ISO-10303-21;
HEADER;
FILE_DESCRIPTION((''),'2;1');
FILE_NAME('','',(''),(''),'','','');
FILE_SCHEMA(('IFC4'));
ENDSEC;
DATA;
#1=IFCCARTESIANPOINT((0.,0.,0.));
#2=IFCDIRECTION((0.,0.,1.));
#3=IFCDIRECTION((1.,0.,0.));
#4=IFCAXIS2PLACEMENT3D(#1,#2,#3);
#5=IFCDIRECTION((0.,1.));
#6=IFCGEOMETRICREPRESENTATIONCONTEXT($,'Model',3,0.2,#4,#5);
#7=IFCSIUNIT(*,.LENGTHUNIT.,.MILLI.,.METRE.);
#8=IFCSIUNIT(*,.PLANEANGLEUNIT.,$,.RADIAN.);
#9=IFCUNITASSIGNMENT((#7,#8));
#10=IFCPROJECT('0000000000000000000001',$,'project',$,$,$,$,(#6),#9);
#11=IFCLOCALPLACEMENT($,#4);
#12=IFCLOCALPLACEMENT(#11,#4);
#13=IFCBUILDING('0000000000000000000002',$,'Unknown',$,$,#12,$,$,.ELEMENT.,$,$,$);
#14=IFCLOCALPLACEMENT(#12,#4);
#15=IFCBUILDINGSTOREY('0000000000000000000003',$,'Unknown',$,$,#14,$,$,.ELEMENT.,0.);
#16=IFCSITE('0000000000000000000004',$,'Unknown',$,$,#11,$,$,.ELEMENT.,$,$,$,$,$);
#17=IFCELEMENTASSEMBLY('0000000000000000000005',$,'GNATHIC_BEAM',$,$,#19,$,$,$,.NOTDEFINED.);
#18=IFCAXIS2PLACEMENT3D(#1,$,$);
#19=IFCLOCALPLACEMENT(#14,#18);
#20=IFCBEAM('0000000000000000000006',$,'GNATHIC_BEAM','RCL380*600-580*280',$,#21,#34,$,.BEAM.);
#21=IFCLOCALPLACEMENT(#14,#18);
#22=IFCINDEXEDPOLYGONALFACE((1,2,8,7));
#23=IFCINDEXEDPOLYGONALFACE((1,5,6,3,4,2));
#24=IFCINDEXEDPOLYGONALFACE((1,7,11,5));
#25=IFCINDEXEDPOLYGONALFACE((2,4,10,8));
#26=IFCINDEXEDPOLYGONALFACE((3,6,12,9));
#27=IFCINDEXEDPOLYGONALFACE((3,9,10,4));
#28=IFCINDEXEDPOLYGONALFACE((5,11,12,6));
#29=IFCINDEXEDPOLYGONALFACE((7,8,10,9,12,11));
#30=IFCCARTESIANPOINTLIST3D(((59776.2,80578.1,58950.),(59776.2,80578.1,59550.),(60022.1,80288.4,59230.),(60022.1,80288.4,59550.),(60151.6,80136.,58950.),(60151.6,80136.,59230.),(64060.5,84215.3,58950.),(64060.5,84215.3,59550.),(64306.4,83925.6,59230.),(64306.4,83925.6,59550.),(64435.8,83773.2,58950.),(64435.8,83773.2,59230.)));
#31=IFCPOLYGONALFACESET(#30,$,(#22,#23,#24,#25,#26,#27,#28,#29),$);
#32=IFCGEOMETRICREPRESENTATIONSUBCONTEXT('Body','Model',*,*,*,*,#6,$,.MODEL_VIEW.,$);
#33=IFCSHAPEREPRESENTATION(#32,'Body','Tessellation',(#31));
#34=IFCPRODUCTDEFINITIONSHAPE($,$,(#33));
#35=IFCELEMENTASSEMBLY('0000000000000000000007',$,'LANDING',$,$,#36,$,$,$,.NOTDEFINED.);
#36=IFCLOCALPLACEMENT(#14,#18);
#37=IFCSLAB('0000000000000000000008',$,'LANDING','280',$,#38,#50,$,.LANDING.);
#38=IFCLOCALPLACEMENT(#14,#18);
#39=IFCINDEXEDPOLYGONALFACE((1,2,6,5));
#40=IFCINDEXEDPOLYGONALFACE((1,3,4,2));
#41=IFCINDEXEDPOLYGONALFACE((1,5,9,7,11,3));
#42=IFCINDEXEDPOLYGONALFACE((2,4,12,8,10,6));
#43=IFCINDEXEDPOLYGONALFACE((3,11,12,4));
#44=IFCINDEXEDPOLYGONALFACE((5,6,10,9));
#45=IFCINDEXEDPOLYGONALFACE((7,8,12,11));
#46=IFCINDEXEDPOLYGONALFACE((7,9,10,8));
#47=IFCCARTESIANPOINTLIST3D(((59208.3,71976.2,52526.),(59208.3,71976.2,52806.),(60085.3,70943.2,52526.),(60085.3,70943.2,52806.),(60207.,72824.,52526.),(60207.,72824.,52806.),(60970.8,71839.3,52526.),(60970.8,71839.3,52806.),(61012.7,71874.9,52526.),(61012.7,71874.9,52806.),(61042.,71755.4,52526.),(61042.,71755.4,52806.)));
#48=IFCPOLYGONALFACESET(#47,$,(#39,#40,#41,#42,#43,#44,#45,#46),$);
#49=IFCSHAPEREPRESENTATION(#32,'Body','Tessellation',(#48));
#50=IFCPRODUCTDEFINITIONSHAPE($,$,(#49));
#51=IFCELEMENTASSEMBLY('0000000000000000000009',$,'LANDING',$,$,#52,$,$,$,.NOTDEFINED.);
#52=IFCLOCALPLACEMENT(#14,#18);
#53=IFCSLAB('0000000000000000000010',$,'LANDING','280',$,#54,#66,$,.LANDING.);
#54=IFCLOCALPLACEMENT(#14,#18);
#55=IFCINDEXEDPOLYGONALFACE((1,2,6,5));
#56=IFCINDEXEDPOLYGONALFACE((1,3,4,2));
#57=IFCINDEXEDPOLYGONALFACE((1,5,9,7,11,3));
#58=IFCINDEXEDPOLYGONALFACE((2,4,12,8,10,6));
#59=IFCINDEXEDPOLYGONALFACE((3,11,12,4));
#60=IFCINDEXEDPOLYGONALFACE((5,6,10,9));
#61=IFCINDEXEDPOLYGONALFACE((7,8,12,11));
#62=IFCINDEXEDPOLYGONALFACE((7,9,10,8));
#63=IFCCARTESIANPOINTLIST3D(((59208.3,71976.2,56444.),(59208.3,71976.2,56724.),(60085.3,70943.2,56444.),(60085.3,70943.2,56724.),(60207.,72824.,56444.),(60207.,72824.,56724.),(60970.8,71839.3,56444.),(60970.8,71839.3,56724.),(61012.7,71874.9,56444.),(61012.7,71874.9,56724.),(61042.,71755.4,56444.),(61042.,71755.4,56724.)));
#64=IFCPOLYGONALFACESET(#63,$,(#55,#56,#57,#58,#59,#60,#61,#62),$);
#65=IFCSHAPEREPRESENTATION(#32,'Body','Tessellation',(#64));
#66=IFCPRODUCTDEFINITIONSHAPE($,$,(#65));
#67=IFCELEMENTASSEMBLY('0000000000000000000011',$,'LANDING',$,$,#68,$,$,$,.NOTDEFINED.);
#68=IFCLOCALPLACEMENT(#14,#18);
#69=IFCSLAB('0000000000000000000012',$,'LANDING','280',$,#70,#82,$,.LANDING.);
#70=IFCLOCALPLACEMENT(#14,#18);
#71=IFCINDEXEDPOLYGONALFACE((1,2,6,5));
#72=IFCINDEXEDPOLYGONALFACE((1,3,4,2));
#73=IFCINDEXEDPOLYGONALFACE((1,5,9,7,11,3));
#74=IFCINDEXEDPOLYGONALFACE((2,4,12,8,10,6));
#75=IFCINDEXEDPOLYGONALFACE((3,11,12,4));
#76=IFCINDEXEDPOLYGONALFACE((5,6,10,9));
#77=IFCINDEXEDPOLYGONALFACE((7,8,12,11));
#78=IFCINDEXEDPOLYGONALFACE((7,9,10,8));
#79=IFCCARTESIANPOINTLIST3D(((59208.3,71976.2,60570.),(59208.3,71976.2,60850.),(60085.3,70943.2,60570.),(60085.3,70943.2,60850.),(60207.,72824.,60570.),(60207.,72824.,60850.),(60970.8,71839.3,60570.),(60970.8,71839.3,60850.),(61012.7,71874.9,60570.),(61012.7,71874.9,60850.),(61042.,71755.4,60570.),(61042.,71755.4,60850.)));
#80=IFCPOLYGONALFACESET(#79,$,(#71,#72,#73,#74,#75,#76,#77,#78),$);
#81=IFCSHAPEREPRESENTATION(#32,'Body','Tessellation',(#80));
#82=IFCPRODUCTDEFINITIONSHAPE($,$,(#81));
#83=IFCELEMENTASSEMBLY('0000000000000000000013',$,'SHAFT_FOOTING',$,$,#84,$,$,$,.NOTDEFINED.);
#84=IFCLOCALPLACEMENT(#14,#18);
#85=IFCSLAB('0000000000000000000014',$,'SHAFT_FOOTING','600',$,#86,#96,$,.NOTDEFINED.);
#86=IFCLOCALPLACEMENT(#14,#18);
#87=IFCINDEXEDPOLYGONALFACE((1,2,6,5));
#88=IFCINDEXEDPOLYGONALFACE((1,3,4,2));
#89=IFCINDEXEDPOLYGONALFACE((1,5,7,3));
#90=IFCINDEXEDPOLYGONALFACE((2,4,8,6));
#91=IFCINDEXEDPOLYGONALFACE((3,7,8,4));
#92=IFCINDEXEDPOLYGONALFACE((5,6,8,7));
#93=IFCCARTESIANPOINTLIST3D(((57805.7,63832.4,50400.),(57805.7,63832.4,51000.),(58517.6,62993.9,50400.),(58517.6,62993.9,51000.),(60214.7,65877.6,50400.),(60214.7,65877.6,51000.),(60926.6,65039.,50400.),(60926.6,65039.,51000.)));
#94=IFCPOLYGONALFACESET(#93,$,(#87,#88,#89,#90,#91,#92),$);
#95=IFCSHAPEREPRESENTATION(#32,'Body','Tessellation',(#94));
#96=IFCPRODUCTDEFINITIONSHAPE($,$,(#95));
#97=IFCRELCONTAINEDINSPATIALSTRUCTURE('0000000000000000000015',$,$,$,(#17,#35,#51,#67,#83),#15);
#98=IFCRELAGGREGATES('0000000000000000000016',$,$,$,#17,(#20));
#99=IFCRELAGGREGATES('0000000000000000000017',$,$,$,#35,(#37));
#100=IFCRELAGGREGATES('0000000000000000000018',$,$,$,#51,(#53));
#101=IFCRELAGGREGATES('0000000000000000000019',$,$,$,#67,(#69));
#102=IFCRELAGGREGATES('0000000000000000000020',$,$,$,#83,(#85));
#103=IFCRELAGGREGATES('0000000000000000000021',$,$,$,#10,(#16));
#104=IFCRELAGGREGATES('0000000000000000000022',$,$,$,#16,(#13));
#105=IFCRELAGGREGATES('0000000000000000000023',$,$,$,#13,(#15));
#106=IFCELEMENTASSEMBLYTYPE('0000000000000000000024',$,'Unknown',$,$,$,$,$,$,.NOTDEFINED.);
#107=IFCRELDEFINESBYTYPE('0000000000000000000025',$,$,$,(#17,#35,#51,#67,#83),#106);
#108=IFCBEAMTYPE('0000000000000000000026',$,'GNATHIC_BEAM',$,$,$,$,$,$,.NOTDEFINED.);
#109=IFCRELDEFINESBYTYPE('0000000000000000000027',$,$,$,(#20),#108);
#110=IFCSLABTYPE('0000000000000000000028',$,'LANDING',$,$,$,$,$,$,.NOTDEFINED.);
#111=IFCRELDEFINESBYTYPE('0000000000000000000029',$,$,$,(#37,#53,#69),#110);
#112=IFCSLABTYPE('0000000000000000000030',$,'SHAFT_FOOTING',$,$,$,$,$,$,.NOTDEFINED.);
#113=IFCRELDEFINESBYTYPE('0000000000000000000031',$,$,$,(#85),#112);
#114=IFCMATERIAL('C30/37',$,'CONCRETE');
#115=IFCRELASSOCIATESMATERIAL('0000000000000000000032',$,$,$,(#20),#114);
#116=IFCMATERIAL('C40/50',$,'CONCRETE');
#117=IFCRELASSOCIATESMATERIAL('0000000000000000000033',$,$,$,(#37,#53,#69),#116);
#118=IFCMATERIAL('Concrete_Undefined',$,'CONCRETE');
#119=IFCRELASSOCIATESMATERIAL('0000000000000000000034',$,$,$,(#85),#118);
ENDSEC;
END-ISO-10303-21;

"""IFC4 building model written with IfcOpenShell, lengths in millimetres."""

from ifc_helpers import new_model, si_unit, direction, frame, origin_with_axes, place, context, subcontext, project, spatial, polyline, line, indexed_curve, outline, extrude, material, material_profile, profile_set, profile_usage, type_object, element, aggregate, save


model = new_model("IFC4")

# Units and contexts
model_context = context("Model", 3, precision=0.2, world=origin_with_axes(), true_north=direction((0.0, 1.0)))
body_context = subcontext(model_context, "Body", "Model", "MODEL_VIEW")
ifc_project = project(units=[si_unit("LENGTHUNIT", "METRE", prefix="MILLI"), si_unit("PLANEANGLEUNIT", "RADIAN")], contexts=[model_context])

# Site, building, storey
site_placement = place(None, origin_with_axes())
site = spatial("IfcSite", under=ifc_project, at=site_placement, Name="Unknown", CompositionType="ELEMENT")
building_placement = place(site_placement, origin_with_axes())
building = spatial("IfcBuilding", under=site, at=building_placement, Name="Unknown", CompositionType="ELEMENT")
storey_placement = place(building_placement, origin_with_axes())
storey = spatial("IfcBuildingStorey", under=building, at=storey_placement, Name="Unknown", CompositionType="ELEMENT", Elevation=0.0)

# Shared definitions
element_assembly_type = type_object("IfcElementAssemblyType", Name="Unknown", PredefinedType="NOTDEFINED")
ifc_material_1 = material(Name="C40/50", Category="CONCRETE")

# Element assembly, beam
ifc_material_2 = material(Name="C30/37", Category="CONCRETE")
ifc_material_profile_1 = material_profile(ifc_material_2, outline(polyline([(-190.0, -300.0), (390.0, -300.0), (390.0, -20.0), (190.0, -20.0), (190.0, 300.0), (-190.0, 300.0), (-190.0, -300.0)])), Name="RCL380*600-580*280")
ifc_profile_set_1 = profile_set([ifc_material_profile_1])
ifc_profile_usage_1 = profile_usage(ifc_profile_set_1, cardinal=2)
beam_type_1 = type_object("IfcBeamType", Name="GNATHIC_BEAM")
assembly_1_placement = place(storey_placement, frame((59899.1, 80433.3, 59250.0), z_axis=(0.64719, -0.762329, 0.0), x_axis=(0.762329, 0.64719, 0.0)))
assembly_1 = element("IfcElementAssembly", 1, at=assembly_1_placement, inside=storey, type_object=element_assembly_type, Name="GNATHIC_BEAM", PredefinedType="NOTDEFINED")
beam_1_placement = place(assembly_1_placement, origin_with_axes())
beam_1 = element("IfcBeam", 2, at=beam_1_placement, type_object=beam_type_1, material=ifc_profile_usage_1, Name="GNATHIC_BEAM", Description="RCL380*600-580*280", PredefinedType="BEAM", context=body_context, shape_type="SolidModel", body=[
    extrude(outline(polyline([(-190.0, -300.0), (390.0, -300.0), (390.0, -20.0), (190.0, -20.0), (190.0, 300.0), (-190.0, 300.0), (-190.0, -300.0)])), frame((0.0, 0.0, 0.0), z_axis=(-1.0, 0.0, 0.0), x_axis=(0.0, 0.0, 1.0)), (0.0, 0.0, -1.0), 5620.0),
])
aggregate(assembly_1, [beam_1])

# Element assemblies, slabs
assembly_2_placement = place(storey_placement, frame((60085.3, 70943.2, 52666.0), z_axis=(0.0, 0.0, -1.0), x_axis=(-0.64719, 0.762329, 0.0)))
assembly_2 = element("IfcElementAssembly", 3, at=assembly_2_placement, inside=storey, type_object=element_assembly_type, Name="LANDING", PredefinedType="NOTDEFINED")
ifc_material_profile_2 = material_profile(ifc_material_1, outline(indexed_curve([(0.0, 0.0), (1355.0, 0.0), (1355.0, 1310.0), (110.0, 1310.0), (110.0, 1255.0), (0.0, 1255.0)], segments=[line(1, 2, 3, 4, 5, 6, 1)])), Name="280")
ifc_profile_set_2 = profile_set([ifc_material_profile_2])
ifc_profile_usage_2 = profile_usage(ifc_profile_set_2, cardinal=2)
slab_type_1 = type_object("IfcSlabType", Name="LANDING")
slab_1_placement = place(assembly_2_placement, origin_with_axes())
slab_1 = element("IfcSlab", 4, at=slab_1_placement, type_object=slab_type_1, material=ifc_profile_usage_2, Name="LANDING", Description="280", PredefinedType="LANDING", context=body_context, shape_type="SolidModel", body=[
    extrude(outline(indexed_curve([(0.0, 0.0), (1355.0, 0.0), (1355.0, 1310.0), (110.0, 1310.0), (110.0, 1255.0), (0.0, 1255.0)], segments=[line(1, 2, 3, 4, 5, 6, 1)])), frame((0.0, 0.0, 140.0), z_axis=(0.0, 0.0, 1.0), x_axis=(1.0, 0.0, 0.0)), (0.0, 0.0, -1.0), 280.0),
])
aggregate(assembly_2, [slab_1])
assembly_3_placement = place(storey_placement, frame((60085.3, 70943.2, 56584.0), z_axis=(0.0, 0.0, -1.0), x_axis=(-0.64719, 0.762329, 0.0)))
assembly_3 = element("IfcElementAssembly", 5, at=assembly_3_placement, inside=storey, type_object=element_assembly_type, Name="LANDING", PredefinedType="NOTDEFINED")
slab_2_placement = place(assembly_3_placement, origin_with_axes())
slab_2 = element("IfcSlab", 6, at=slab_2_placement, type_object=slab_type_1, material=ifc_profile_usage_2, Name="LANDING", Description="280", PredefinedType="LANDING", context=body_context, shape_type="SolidModel", body=[
    extrude(outline(indexed_curve([(0.0, 0.0), (1355.0, 0.0), (1355.0, 1310.0), (110.0, 1310.0), (110.0, 1255.0), (0.0, 1255.0)], segments=[line(1, 2, 3, 4, 5, 6, 1)])), frame((0.0, 0.0, 140.0), z_axis=(0.0, 0.0, 1.0), x_axis=(1.0, 0.0, 0.0)), (0.0, 0.0, -1.0), 280.0),
])
aggregate(assembly_3, [slab_2])
assembly_4_placement = place(storey_placement, frame((60085.3, 70943.2, 60710.0), z_axis=(0.0, 0.0, -1.0), x_axis=(-0.64719, 0.762329, 0.0)))
assembly_4 = element("IfcElementAssembly", 7, at=assembly_4_placement, inside=storey, type_object=element_assembly_type, Name="LANDING", PredefinedType="NOTDEFINED")
slab_3_placement = place(assembly_4_placement, origin_with_axes())
slab_3 = element("IfcSlab", 8, at=slab_3_placement, type_object=slab_type_1, material=ifc_profile_usage_2, Name="LANDING", Description="280", PredefinedType="LANDING", context=body_context, shape_type="SolidModel", body=[
    extrude(outline(indexed_curve([(0.0, 0.0), (1355.0, 0.0), (1355.0, 1310.0), (110.0, 1310.0), (110.0, 1255.0), (0.0, 1255.0)], segments=[line(1, 2, 3, 4, 5, 6, 1)])), frame((0.0, 0.0, 140.0), z_axis=(0.0, 0.0, 1.0), x_axis=(1.0, 0.0, 0.0)), (0.0, 0.0, -1.0), 280.0),
])
aggregate(assembly_4, [slab_3])
assembly_5_placement = place(storey_placement, frame((60214.7, 65877.6, 50700.0), z_axis=(0.0, 0.0, 1.0), x_axis=(-0.762329, -0.64719, 0.0)))
assembly_5 = element("IfcElementAssembly", 9, at=assembly_5_placement, inside=storey, type_object=element_assembly_type, Name="SHAFT_FOOTING", PredefinedType="NOTDEFINED")
ifc_material_3 = material(Name="Concrete_Undefined", Category="CONCRETE")
ifc_material_profile_3 = material_profile(ifc_material_3, outline(indexed_curve([(0.0, 0.0), (3160.0, 0.0), (3160.0, 1100.0), (0.0, 1100.0)], segments=[line(1, 2, 3, 4, 1)])), Name="600")
ifc_profile_set_3 = profile_set([ifc_material_profile_3])
ifc_profile_usage_3 = profile_usage(ifc_profile_set_3, cardinal=8)
slab_type_2 = type_object("IfcSlabType", Name="SHAFT_FOOTING")
slab_4_placement = place(assembly_5_placement, origin_with_axes())
slab_4 = element("IfcSlab", 10, at=slab_4_placement, type_object=slab_type_2, material=ifc_profile_usage_3, Name="SHAFT_FOOTING", Description="600", PredefinedType="NOTDEFINED", context=body_context, shape_type="SolidModel", body=[
    extrude(outline(indexed_curve([(0.0, 0.0), (3160.0, 0.0), (3160.0, 1100.0), (0.0, 1100.0)], segments=[line(1, 2, 3, 4, 1)])), frame((0.0, 0.0, 300.0), z_axis=(0.0, 0.0, 1.0), x_axis=(1.0, 0.0, 0.0)), (0.0, 0.0, -1.0), 600.0),
])
aggregate(assembly_5, [slab_4])

save(model, "model.ifc")
